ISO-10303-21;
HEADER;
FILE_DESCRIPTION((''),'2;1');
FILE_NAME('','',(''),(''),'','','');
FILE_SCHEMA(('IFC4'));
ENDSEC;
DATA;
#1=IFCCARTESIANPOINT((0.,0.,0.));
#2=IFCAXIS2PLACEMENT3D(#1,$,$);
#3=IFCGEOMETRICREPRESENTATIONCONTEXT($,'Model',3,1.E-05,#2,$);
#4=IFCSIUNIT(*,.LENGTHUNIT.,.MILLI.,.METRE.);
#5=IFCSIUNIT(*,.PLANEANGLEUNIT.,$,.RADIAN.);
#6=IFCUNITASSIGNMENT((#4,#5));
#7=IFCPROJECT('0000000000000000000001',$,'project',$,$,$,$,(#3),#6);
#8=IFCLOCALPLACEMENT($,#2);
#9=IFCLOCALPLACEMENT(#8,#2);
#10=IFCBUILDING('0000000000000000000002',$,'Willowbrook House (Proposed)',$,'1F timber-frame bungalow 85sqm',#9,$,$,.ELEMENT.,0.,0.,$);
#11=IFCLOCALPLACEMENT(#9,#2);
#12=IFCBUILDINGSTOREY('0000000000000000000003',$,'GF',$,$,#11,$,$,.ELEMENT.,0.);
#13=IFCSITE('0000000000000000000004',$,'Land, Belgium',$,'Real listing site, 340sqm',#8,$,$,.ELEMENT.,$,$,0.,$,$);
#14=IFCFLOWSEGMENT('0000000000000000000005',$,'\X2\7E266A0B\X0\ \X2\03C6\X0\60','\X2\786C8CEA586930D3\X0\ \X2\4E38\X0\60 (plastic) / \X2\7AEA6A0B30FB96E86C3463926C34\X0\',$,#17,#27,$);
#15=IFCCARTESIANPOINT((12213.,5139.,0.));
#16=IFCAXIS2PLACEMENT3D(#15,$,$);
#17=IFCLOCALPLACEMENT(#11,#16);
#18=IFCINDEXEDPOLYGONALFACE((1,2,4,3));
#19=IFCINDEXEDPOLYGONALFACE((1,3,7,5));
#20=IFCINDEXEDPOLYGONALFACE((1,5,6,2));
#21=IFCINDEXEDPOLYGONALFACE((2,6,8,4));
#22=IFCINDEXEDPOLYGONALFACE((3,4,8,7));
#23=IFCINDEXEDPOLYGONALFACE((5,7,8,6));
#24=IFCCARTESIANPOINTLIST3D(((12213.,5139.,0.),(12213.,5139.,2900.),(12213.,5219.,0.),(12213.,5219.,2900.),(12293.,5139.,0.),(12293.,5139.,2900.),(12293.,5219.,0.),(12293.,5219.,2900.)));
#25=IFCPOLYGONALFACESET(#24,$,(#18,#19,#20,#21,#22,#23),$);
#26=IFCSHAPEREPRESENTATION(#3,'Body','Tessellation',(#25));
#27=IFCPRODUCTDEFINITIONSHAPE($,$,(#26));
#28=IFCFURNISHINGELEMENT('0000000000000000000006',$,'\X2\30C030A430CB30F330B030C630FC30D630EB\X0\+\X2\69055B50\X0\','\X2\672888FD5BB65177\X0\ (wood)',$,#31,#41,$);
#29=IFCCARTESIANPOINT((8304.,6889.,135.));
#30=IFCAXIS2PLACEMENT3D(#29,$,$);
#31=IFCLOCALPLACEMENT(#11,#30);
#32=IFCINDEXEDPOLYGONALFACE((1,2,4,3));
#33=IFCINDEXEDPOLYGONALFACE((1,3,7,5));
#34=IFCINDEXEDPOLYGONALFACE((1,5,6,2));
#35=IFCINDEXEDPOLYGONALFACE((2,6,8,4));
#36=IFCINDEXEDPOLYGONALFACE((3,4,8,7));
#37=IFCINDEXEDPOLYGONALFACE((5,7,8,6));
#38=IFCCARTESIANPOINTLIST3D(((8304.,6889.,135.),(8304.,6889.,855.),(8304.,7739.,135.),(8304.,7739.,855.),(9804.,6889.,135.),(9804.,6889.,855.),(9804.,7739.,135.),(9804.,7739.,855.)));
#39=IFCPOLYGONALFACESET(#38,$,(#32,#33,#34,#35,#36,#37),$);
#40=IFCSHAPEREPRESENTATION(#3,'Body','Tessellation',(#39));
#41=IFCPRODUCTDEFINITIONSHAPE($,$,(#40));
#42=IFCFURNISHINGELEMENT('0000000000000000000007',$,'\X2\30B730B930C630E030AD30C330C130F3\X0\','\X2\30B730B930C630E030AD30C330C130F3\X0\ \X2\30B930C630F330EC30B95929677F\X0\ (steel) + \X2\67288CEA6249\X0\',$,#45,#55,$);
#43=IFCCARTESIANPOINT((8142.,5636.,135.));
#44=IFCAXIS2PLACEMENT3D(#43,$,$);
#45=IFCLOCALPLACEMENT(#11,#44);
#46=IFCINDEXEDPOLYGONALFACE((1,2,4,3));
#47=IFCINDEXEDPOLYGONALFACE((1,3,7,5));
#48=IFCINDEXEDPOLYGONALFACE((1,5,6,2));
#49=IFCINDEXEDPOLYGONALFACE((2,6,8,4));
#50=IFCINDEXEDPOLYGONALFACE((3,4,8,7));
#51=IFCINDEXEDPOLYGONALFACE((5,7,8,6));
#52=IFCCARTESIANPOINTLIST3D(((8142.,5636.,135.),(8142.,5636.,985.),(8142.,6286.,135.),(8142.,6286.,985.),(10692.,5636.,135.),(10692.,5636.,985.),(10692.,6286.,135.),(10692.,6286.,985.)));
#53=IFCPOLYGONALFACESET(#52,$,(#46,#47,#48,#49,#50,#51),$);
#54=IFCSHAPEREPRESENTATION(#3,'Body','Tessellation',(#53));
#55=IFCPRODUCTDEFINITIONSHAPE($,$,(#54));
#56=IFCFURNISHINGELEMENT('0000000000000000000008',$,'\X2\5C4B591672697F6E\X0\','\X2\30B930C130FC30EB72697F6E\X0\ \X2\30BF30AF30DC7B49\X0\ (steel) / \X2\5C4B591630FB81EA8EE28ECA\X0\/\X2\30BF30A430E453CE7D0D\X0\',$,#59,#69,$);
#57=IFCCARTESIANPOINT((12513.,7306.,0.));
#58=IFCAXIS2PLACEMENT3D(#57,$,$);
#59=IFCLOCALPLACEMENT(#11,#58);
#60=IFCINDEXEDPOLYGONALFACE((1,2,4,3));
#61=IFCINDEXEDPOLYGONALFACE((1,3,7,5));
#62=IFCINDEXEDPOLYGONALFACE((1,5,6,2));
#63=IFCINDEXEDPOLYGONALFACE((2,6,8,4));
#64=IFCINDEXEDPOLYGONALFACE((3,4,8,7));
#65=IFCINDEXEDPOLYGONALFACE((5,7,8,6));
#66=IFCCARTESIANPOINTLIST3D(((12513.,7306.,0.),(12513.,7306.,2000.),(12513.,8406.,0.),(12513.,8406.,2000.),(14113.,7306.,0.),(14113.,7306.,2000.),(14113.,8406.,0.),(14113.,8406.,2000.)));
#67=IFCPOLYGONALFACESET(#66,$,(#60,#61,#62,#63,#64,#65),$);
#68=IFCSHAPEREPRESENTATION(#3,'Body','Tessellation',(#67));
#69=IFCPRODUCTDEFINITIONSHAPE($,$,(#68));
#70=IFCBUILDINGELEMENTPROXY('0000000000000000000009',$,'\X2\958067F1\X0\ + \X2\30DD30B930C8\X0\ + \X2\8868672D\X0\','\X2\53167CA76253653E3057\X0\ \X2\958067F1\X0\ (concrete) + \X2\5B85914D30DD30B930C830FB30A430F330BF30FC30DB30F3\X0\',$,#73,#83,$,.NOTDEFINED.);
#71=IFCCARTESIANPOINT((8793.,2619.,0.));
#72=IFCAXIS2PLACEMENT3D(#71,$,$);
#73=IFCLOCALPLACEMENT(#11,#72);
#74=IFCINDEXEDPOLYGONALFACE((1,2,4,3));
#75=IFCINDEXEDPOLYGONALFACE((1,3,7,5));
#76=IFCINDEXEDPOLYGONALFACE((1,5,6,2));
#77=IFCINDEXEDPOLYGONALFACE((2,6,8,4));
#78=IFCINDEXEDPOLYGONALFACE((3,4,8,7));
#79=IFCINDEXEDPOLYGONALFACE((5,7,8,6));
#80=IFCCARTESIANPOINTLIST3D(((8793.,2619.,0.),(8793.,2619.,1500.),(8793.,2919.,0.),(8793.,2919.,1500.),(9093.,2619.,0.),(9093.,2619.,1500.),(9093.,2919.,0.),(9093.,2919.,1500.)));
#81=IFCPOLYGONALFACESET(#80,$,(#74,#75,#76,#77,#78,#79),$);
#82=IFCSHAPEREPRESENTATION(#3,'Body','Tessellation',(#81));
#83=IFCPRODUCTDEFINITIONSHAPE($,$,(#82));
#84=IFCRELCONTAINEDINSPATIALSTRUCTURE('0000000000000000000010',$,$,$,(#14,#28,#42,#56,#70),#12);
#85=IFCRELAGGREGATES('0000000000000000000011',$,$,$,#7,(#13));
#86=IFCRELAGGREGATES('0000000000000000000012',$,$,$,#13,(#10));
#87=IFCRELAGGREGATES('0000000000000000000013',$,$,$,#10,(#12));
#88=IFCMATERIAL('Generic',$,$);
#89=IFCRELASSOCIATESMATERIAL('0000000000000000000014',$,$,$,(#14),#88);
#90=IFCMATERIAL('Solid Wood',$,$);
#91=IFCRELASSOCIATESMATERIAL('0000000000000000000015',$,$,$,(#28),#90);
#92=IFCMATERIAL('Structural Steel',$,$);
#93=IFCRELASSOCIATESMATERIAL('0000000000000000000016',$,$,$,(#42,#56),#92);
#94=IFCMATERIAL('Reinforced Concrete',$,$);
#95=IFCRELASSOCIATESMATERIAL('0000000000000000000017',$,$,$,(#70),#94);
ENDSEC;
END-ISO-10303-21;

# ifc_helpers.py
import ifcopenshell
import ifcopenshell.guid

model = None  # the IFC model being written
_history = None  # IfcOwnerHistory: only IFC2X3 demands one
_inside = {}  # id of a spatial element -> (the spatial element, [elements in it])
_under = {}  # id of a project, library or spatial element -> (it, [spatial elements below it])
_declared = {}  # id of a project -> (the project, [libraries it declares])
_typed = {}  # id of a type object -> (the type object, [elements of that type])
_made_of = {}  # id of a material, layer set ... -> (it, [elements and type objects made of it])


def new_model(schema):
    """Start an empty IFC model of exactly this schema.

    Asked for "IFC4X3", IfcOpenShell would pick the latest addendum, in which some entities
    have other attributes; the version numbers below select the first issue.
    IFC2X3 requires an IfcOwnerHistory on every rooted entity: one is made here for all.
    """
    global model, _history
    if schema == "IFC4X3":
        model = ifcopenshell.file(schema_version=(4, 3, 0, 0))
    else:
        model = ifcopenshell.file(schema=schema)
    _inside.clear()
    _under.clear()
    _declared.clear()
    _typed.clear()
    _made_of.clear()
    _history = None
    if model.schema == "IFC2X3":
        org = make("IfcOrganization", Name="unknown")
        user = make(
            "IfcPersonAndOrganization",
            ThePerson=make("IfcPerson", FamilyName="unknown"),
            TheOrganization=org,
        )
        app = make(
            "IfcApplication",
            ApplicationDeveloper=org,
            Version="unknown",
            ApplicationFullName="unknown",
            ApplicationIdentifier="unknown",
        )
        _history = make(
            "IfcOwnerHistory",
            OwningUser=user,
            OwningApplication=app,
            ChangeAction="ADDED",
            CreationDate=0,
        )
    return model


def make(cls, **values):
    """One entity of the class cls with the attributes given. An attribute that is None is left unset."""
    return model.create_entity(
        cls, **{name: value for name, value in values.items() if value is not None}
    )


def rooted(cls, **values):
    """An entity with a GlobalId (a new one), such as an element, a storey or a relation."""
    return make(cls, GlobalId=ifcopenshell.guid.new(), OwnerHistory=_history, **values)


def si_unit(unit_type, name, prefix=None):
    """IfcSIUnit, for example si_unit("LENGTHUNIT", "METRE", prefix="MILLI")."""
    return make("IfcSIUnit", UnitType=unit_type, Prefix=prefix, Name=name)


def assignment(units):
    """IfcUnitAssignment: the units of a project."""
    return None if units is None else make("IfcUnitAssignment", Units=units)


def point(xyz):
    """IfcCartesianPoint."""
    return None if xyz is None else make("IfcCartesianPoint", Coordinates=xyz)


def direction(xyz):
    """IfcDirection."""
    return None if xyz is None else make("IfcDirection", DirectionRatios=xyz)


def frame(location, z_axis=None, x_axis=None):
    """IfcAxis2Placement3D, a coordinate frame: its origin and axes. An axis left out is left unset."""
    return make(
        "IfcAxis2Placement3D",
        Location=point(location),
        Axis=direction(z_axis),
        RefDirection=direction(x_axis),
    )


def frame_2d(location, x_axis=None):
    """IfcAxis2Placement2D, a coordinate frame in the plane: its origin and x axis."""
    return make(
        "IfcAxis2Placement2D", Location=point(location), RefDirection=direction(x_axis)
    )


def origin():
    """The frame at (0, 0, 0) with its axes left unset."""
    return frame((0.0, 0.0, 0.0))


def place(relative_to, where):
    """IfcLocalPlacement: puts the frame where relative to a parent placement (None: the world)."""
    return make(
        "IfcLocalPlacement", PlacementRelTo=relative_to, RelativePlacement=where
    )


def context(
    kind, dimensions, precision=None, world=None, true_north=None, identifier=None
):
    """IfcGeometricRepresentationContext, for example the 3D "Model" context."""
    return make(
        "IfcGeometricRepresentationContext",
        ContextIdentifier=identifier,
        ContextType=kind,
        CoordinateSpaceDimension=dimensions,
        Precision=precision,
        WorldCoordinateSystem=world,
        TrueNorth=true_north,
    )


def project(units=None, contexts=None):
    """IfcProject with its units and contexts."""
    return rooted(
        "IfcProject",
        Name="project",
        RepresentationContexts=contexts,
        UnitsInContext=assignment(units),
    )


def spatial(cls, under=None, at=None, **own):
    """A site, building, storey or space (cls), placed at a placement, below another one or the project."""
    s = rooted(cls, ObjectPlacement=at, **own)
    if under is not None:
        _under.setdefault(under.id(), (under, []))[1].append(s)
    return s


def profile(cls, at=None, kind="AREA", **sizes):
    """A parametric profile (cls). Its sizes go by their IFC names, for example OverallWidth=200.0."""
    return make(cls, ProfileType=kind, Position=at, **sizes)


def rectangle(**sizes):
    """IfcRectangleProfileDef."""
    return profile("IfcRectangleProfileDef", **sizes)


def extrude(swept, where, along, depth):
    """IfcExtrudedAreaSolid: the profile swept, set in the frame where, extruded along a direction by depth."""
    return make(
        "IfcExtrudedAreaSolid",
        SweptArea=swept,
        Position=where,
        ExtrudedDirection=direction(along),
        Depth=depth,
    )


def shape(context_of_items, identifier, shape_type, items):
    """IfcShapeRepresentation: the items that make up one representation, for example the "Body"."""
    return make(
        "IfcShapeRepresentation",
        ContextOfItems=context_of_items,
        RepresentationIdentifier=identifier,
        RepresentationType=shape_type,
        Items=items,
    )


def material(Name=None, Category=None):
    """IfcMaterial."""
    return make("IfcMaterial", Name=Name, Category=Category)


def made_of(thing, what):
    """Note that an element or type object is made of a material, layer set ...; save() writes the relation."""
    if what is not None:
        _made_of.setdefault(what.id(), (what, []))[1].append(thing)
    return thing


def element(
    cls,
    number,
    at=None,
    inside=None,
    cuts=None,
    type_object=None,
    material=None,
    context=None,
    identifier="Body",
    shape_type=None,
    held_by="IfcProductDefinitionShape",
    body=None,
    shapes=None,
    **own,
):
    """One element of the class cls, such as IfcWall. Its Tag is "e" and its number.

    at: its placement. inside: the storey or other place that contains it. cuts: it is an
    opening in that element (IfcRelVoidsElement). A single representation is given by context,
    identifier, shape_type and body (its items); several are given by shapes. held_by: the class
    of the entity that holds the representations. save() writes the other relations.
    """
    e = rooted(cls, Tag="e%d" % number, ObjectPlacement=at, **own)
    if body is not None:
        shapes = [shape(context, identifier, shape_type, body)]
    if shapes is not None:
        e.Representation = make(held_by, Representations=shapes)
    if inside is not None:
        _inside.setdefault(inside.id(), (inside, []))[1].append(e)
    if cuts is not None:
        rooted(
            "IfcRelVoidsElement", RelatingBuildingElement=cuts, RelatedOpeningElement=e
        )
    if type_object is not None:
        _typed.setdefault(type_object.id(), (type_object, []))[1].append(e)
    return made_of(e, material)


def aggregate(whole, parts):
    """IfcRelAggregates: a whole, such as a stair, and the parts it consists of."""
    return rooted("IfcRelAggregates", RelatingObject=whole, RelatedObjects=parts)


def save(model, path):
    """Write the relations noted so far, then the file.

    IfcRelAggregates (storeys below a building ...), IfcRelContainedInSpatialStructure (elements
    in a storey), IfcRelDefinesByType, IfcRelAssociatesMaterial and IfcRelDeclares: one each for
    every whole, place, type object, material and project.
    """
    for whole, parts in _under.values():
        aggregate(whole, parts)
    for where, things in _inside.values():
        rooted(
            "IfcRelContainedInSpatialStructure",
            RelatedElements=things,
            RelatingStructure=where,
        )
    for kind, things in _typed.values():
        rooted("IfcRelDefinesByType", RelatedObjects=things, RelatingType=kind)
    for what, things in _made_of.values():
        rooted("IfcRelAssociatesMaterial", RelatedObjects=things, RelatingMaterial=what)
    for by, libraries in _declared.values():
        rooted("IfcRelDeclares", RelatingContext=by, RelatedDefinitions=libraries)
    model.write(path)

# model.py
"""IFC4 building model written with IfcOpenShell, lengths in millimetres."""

from ifc_helpers import new_model, si_unit, frame, frame_2d, origin, place, context, project, spatial, rectangle, extrude, material, element, save


model = new_model("IFC4")

# Units and contexts
model_context = context("Model", 3, precision=1e-05, world=origin())
ifc_project = project(units=[si_unit("LENGTHUNIT", "METRE", prefix="MILLI"), si_unit("PLANEANGLEUNIT", "RADIAN")], contexts=[model_context])

# Site, building, storey
site_placement = place(None, origin())
site = spatial("IfcSite", under=ifc_project, at=site_placement, Name="Land, Belgium", ObjectType="Real listing site, 340sqm", CompositionType="ELEMENT", RefElevation=0.0)
building_placement = place(site_placement, origin())
building = spatial("IfcBuilding", under=site, at=building_placement, Name="Willowbrook House (Proposed)", ObjectType="1F timber-frame bungalow 85sqm", CompositionType="ELEMENT", ElevationOfRefHeight=0.0, ElevationOfTerrain=0.0)
storey_placement = place(building_placement, origin())
storey = spatial("IfcBuildingStorey", under=building, at=storey_placement, Name="GF", CompositionType="ELEMENT", Elevation=0.0)

# Shared definitions
ifc_material_1 = material(Name="Solid Wood")

# Shared definitions
ifc_material_2 = material(Name="Structural Steel")

# Shared definitions
ifc_material_3 = material(Name="Reinforced Concrete")

# Shared definitions
ifc_material_4 = material(Name="Generic")

# Flow segment
flow_segment_placement = place(storey_placement, frame((12213.0, 5139.0, 0.0)))
element("IfcFlowSegment", 1, at=flow_segment_placement, inside=storey, material=ifc_material_4, Name="縦樋 φ60", Description="硬質塩ビ 丸60 (plastic) / 竪樋・雨水排水", context=model_context, shape_type="SweptSolid", body=[
    extrude(rectangle(XDim=80.0, YDim=80.0, at=frame_2d((40.0, 40.0))), frame((12213.0, 5139.0, 0.0)), (0.0, 0.0, 1.0), 2900.0),
])

# Furnishing elements
furnishing_1_placement = place(storey_placement, frame((8304.0, 6889.0, 135.0)))
element("IfcFurnishingElement", 2, at=furnishing_1_placement, inside=storey, material=ifc_material_1, Name="ダイニングテーブル+椅子", Description="木製家具 (wood)", context=model_context, shape_type="SweptSolid", body=[
    extrude(rectangle(XDim=1500.0, YDim=850.0, at=frame_2d((750.0, 425.0))), frame((8304.0, 6889.0, 135.0)), (0.0, 0.0, 1.0), 720.0),
])
furnishing_2_placement = place(storey_placement, frame((8142.0, 5636.0, 135.0)))
element("IfcFurnishingElement", 3, at=furnishing_2_placement, inside=storey, material=ifc_material_2, Name="システムキッチン", Description="システムキッチン ステンレス天板 (steel) + 木質扉", context=model_context, shape_type="SweptSolid", body=[
    extrude(rectangle(XDim=2550.0, YDim=650.0, at=frame_2d((1275.0, 325.0))), frame((8142.0, 5636.0, 135.0)), (0.0, 0.0, 1.0), 850.0),
])
furnishing_3_placement = place(storey_placement, frame((12513.0, 7306.0, 0.0)))
element("IfcFurnishingElement", 4, at=furnishing_3_placement, inside=storey, material=ifc_material_2, Name="屋外物置", Description="スチール物置 タクボ等 (steel) / 屋外・自転車/タイヤ収納", context=model_context, shape_type="SweptSolid", body=[
    extrude(rectangle(XDim=1600.0, YDim=1100.0, at=frame_2d((800.0, 550.0))), frame((12513.0, 7306.0, 0.0)), (0.0, 0.0, 1.0), 2000.0),
])

# Building element proxy
proxy_placement = place(storey_placement, frame((8793.0, 2619.0, 0.0)))
element("IfcBuildingElementProxy", 5, at=proxy_placement, inside=storey, material=ifc_material_3, Name="門柱 + ポスト + 表札", Description="化粧打放し 門柱 (concrete) + 宅配ポスト・インターホン", PredefinedType="NOTDEFINED", context=model_context, shape_type="SweptSolid", body=[
    extrude(rectangle(XDim=300.0, YDim=300.0, at=frame_2d((150.0, 150.0))), frame((8793.0, 2619.0, 0.0)), (0.0, 0.0, 1.0), 1500.0),
])

save(model, "model.ifc")
